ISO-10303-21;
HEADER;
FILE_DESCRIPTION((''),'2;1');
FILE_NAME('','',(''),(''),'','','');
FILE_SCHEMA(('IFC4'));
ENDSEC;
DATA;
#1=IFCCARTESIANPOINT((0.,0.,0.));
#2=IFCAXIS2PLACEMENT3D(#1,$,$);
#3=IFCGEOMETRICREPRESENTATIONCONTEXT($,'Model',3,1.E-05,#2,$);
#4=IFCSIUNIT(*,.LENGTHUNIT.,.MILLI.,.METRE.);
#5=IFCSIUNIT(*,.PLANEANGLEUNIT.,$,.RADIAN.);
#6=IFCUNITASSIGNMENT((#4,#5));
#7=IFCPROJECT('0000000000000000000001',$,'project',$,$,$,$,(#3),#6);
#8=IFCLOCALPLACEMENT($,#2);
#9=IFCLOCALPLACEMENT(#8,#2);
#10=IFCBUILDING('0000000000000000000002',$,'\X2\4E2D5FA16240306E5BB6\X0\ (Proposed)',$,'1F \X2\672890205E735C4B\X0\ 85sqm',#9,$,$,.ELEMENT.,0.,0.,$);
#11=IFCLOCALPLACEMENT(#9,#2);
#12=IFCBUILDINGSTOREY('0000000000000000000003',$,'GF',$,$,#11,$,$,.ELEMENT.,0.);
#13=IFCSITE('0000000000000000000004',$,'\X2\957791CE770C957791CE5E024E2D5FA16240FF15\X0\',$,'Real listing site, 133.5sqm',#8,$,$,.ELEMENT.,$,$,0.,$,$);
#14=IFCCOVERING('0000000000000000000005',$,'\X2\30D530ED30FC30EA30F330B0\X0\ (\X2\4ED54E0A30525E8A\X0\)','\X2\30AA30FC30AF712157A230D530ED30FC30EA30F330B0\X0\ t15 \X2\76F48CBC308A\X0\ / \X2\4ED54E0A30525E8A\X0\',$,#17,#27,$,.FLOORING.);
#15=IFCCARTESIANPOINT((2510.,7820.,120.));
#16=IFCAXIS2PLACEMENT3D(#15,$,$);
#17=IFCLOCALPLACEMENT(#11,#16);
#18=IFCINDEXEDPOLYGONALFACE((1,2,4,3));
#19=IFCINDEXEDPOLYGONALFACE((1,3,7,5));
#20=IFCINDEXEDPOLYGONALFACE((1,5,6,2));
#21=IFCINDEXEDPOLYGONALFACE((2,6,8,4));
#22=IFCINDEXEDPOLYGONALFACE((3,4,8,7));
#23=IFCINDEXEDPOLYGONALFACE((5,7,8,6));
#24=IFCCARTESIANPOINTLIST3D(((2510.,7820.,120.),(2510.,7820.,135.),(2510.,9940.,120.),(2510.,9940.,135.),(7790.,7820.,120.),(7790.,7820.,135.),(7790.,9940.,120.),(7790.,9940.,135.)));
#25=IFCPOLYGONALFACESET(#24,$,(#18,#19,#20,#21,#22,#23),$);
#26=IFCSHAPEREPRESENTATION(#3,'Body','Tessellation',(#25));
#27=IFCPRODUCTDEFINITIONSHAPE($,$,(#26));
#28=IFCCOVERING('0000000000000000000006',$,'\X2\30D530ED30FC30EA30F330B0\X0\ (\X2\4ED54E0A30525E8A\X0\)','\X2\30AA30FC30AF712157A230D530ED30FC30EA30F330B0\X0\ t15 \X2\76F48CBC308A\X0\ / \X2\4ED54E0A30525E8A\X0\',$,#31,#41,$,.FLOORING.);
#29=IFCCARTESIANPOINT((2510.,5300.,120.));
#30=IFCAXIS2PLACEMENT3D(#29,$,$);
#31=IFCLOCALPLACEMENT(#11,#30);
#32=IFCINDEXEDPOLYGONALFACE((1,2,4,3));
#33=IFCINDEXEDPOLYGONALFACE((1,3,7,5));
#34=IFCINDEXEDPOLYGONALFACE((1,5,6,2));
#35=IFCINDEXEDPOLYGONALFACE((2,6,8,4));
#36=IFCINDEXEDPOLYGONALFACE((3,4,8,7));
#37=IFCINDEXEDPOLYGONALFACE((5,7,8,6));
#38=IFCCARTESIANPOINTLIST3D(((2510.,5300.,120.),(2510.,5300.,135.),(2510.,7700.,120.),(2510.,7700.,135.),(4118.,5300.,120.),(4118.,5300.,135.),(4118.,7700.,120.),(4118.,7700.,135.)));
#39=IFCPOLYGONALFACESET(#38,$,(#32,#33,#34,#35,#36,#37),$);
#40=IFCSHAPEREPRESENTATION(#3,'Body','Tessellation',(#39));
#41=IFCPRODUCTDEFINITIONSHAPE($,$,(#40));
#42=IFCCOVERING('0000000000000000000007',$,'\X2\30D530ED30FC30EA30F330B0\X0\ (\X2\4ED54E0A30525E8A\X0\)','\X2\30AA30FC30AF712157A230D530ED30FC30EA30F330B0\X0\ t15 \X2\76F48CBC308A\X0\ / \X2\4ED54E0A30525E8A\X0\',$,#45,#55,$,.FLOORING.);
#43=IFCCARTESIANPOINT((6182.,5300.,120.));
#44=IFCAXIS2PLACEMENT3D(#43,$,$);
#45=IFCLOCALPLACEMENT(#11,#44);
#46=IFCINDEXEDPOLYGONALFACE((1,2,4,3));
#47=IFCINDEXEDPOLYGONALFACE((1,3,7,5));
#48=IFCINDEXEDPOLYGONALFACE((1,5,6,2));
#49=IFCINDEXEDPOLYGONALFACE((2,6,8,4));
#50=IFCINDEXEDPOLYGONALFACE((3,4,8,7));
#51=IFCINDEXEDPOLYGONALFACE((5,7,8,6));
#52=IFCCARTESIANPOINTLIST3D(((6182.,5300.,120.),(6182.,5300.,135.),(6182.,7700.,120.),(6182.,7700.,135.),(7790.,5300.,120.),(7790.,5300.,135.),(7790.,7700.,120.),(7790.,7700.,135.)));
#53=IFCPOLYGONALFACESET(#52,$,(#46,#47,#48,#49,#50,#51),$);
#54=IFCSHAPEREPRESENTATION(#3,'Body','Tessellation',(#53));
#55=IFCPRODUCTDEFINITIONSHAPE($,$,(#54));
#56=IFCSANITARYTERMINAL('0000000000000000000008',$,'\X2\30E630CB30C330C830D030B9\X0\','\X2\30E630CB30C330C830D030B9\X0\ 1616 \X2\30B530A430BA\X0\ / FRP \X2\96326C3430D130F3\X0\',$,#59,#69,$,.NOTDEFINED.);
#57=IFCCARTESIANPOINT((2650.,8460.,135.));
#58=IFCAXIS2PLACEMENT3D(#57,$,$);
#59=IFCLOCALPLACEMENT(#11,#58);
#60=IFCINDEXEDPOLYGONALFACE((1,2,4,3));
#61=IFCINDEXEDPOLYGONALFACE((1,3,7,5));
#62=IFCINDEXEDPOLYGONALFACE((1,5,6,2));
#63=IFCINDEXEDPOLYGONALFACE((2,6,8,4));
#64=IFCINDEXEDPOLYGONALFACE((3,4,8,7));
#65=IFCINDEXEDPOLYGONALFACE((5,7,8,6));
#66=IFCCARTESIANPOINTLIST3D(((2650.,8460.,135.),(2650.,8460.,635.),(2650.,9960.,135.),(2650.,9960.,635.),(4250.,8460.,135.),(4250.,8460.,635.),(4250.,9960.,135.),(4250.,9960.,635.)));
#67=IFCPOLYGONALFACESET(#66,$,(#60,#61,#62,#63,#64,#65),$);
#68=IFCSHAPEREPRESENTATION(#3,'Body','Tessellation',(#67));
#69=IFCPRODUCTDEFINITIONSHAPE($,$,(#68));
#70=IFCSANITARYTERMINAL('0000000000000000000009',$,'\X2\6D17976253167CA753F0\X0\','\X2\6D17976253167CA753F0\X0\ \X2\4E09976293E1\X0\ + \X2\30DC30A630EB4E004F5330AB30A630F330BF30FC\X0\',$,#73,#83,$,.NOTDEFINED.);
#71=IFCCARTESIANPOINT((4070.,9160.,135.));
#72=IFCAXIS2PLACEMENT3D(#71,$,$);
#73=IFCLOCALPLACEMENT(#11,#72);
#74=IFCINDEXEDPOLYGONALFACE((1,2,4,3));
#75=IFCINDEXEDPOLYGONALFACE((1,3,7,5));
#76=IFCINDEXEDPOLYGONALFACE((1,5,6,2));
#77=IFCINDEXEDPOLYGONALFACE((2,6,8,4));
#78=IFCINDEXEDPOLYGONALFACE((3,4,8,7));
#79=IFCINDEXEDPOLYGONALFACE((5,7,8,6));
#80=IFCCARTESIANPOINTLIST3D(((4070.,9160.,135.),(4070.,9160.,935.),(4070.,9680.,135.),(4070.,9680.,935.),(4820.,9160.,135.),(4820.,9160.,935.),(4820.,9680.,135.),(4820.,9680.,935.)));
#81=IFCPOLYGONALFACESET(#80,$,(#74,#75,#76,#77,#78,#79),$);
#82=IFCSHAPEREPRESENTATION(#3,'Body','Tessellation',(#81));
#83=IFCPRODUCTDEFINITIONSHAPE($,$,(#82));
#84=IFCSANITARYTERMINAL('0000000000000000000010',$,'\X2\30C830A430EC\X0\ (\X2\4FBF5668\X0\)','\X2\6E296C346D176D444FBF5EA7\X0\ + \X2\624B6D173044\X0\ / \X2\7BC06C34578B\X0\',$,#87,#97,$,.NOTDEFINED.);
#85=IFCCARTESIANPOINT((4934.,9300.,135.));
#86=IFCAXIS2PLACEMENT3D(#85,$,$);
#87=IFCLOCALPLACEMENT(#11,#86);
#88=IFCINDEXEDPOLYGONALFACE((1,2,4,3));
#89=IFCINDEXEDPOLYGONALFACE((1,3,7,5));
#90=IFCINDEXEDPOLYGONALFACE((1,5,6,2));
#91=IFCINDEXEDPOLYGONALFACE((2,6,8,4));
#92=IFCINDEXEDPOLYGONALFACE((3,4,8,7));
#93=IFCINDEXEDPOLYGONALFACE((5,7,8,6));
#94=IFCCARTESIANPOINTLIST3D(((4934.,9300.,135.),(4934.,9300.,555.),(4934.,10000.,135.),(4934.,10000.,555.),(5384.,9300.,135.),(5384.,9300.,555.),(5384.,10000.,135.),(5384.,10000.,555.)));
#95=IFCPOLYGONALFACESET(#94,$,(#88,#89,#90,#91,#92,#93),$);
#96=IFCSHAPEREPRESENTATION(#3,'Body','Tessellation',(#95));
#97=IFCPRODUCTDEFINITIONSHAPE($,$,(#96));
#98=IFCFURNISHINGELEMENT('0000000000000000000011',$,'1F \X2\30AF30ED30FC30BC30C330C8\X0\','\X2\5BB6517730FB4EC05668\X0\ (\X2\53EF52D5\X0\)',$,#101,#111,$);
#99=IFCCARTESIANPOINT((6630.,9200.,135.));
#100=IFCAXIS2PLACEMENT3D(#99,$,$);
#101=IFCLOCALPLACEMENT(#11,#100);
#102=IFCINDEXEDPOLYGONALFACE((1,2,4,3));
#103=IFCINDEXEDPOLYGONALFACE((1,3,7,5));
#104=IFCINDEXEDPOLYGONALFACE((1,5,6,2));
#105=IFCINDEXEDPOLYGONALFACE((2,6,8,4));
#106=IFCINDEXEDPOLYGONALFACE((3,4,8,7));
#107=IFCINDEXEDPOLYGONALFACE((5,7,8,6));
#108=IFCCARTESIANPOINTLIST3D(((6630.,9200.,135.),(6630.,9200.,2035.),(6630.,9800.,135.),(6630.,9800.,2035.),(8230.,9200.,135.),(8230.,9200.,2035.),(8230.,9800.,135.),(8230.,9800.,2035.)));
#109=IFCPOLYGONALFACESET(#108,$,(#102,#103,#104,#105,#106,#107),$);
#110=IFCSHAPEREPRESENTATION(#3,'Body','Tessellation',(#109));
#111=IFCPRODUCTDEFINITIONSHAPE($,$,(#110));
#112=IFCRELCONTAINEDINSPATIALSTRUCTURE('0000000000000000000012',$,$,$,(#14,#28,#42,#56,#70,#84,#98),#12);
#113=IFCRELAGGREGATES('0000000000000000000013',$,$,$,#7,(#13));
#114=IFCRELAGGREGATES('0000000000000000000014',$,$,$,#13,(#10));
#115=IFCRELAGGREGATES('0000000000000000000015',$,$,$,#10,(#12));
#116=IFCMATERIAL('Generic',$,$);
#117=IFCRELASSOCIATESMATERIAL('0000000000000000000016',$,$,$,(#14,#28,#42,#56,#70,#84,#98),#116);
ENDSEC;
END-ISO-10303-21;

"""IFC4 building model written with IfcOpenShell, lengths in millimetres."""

from ifc_helpers import new_model, si_unit, frame, frame_2d, origin, place, context, project, spatial, rectangle, extrude, material, element, save


model = new_model("IFC4")

# Units and contexts
model_context = context("Model", 3, precision=1e-05, world=origin())
ifc_project = project(units=[si_unit("LENGTHUNIT", "METRE", prefix="MILLI"), si_unit("PLANEANGLEUNIT", "RADIAN")], contexts=[model_context])

# Site, building, storey
site_placement = place(None, origin())
site = spatial("IfcSite", under=ifc_project, at=site_placement, Name="長野県長野市中御所５", ObjectType="Real listing site, 133.5sqm", CompositionType="ELEMENT", RefElevation=0.0)
building_placement = place(site_placement, origin())
building = spatial("IfcBuilding", under=site, at=building_placement, Name="中御所の家 (Proposed)", ObjectType="1F 木造平屋 85sqm", CompositionType="ELEMENT", ElevationOfRefHeight=0.0, ElevationOfTerrain=0.0)
storey_placement = place(building_placement, origin())
storey = spatial("IfcBuildingStorey", under=building, at=storey_placement, Name="GF", CompositionType="ELEMENT", Elevation=0.0)

# Coverings
ifc_material_1 = material(Name="Generic")
covering_1_placement = place(storey_placement, frame((2510.0, 7820.0, 120.0)))
element("IfcCovering", 1, at=covering_1_placement, inside=storey, material=ifc_material_1, Name="フローリング (仕上げ床)", Description="オーク無垢フローリング t15 直貼り / 仕上げ床", PredefinedType="FLOORING", context=model_context, shape_type="SweptSolid", body=[
    extrude(rectangle(XDim=5280.0, YDim=2120.0, at=frame_2d((2640.0, 1060.0))), frame((2510.0, 7820.0, 120.0)), (0.0, 0.0, 1.0), 15.0),
])
covering_2_placement = place(storey_placement, frame((2510.0, 5300.0, 120.0)))
element("IfcCovering", 2, at=covering_2_placement, inside=storey, material=ifc_material_1, Name="フローリング (仕上げ床)", Description="オーク無垢フローリング t15 直貼り / 仕上げ床", PredefinedType="FLOORING", context=model_context, shape_type="SweptSolid", body=[
    extrude(rectangle(XDim=1608.0, YDim=2400.0, at=frame_2d((804.0, 1200.0))), frame((2510.0, 5300.0, 120.0)), (0.0, 0.0, 1.0), 15.0),
])
covering_3_placement = place(storey_placement, frame((6182.0, 5300.0, 120.0)))
element("IfcCovering", 3, at=covering_3_placement, inside=storey, material=ifc_material_1, Name="フローリング (仕上げ床)", Description="オーク無垢フローリング t15 直貼り / 仕上げ床", PredefinedType="FLOORING", context=model_context, shape_type="SweptSolid", body=[
    extrude(rectangle(XDim=1608.0, YDim=2400.0, at=frame_2d((804.0, 1200.0))), frame((6182.0, 5300.0, 120.0)), (0.0, 0.0, 1.0), 15.0),
])

# Sanitary terminals
sanitary_terminal_1_placement = place(storey_placement, frame((2650.0, 8460.0, 135.0)))
element("IfcSanitaryTerminal", 4, at=sanitary_terminal_1_placement, inside=storey, material=ifc_material_1, Name="ユニットバス", Description="ユニットバス 1616 サイズ / FRP 防水パン", PredefinedType="NOTDEFINED", context=model_context, shape_type="SweptSolid", body=[
    extrude(rectangle(XDim=1600.0, YDim=1500.0, at=frame_2d((800.0, 750.0))), frame((2650.0, 8460.0, 135.0)), (0.0, 0.0, 1.0), 500.0),
])
sanitary_terminal_2_placement = place(storey_placement, frame((4070.0, 9160.0, 135.0)))
element("IfcSanitaryTerminal", 5, at=sanitary_terminal_2_placement, inside=storey, material=ifc_material_1, Name="洗面化粧台", Description="洗面化粧台 三面鏡 + ボウル一体カウンター", PredefinedType="NOTDEFINED", context=model_context, shape_type="SweptSolid", body=[
    extrude(rectangle(XDim=750.0, YDim=520.0, at=frame_2d((375.0, 260.0))), frame((4070.0, 9160.0, 135.0)), (0.0, 0.0, 1.0), 800.0),
])
sanitary_terminal_3_placement = place(storey_placement, frame((4934.0, 9300.0, 135.0)))
element("IfcSanitaryTerminal", 6, at=sanitary_terminal_3_placement, inside=storey, material=ifc_material_1, Name="トイレ (便器)", Description="温水洗浄便座 + 手洗い / 節水型", PredefinedType="NOTDEFINED", context=model_context, shape_type="SweptSolid", body=[
    extrude(rectangle(XDim=450.0, YDim=700.0, at=frame_2d((225.0, 350.0))), frame((4934.0, 9300.0, 135.0)), (0.0, 0.0, 1.0), 420.0),
])

# Furnishing element
furnishing_placement = place(storey_placement, frame((6630.0, 9200.0, 135.0)))
element("IfcFurnishingElement", 7, at=furnishing_placement, inside=storey, material=ifc_material_1, Name="1F クローゼット", Description="家具・什器 (可動)", context=model_context, shape_type="SweptSolid", body=[
    extrude(rectangle(XDim=1600.0, YDim=600.0, at=frame_2d((800.0, 300.0))), frame((6630.0, 9200.0, 135.0)), (0.0, 0.0, 1.0), 1900.0),
])

save(model, "model.ifc")
